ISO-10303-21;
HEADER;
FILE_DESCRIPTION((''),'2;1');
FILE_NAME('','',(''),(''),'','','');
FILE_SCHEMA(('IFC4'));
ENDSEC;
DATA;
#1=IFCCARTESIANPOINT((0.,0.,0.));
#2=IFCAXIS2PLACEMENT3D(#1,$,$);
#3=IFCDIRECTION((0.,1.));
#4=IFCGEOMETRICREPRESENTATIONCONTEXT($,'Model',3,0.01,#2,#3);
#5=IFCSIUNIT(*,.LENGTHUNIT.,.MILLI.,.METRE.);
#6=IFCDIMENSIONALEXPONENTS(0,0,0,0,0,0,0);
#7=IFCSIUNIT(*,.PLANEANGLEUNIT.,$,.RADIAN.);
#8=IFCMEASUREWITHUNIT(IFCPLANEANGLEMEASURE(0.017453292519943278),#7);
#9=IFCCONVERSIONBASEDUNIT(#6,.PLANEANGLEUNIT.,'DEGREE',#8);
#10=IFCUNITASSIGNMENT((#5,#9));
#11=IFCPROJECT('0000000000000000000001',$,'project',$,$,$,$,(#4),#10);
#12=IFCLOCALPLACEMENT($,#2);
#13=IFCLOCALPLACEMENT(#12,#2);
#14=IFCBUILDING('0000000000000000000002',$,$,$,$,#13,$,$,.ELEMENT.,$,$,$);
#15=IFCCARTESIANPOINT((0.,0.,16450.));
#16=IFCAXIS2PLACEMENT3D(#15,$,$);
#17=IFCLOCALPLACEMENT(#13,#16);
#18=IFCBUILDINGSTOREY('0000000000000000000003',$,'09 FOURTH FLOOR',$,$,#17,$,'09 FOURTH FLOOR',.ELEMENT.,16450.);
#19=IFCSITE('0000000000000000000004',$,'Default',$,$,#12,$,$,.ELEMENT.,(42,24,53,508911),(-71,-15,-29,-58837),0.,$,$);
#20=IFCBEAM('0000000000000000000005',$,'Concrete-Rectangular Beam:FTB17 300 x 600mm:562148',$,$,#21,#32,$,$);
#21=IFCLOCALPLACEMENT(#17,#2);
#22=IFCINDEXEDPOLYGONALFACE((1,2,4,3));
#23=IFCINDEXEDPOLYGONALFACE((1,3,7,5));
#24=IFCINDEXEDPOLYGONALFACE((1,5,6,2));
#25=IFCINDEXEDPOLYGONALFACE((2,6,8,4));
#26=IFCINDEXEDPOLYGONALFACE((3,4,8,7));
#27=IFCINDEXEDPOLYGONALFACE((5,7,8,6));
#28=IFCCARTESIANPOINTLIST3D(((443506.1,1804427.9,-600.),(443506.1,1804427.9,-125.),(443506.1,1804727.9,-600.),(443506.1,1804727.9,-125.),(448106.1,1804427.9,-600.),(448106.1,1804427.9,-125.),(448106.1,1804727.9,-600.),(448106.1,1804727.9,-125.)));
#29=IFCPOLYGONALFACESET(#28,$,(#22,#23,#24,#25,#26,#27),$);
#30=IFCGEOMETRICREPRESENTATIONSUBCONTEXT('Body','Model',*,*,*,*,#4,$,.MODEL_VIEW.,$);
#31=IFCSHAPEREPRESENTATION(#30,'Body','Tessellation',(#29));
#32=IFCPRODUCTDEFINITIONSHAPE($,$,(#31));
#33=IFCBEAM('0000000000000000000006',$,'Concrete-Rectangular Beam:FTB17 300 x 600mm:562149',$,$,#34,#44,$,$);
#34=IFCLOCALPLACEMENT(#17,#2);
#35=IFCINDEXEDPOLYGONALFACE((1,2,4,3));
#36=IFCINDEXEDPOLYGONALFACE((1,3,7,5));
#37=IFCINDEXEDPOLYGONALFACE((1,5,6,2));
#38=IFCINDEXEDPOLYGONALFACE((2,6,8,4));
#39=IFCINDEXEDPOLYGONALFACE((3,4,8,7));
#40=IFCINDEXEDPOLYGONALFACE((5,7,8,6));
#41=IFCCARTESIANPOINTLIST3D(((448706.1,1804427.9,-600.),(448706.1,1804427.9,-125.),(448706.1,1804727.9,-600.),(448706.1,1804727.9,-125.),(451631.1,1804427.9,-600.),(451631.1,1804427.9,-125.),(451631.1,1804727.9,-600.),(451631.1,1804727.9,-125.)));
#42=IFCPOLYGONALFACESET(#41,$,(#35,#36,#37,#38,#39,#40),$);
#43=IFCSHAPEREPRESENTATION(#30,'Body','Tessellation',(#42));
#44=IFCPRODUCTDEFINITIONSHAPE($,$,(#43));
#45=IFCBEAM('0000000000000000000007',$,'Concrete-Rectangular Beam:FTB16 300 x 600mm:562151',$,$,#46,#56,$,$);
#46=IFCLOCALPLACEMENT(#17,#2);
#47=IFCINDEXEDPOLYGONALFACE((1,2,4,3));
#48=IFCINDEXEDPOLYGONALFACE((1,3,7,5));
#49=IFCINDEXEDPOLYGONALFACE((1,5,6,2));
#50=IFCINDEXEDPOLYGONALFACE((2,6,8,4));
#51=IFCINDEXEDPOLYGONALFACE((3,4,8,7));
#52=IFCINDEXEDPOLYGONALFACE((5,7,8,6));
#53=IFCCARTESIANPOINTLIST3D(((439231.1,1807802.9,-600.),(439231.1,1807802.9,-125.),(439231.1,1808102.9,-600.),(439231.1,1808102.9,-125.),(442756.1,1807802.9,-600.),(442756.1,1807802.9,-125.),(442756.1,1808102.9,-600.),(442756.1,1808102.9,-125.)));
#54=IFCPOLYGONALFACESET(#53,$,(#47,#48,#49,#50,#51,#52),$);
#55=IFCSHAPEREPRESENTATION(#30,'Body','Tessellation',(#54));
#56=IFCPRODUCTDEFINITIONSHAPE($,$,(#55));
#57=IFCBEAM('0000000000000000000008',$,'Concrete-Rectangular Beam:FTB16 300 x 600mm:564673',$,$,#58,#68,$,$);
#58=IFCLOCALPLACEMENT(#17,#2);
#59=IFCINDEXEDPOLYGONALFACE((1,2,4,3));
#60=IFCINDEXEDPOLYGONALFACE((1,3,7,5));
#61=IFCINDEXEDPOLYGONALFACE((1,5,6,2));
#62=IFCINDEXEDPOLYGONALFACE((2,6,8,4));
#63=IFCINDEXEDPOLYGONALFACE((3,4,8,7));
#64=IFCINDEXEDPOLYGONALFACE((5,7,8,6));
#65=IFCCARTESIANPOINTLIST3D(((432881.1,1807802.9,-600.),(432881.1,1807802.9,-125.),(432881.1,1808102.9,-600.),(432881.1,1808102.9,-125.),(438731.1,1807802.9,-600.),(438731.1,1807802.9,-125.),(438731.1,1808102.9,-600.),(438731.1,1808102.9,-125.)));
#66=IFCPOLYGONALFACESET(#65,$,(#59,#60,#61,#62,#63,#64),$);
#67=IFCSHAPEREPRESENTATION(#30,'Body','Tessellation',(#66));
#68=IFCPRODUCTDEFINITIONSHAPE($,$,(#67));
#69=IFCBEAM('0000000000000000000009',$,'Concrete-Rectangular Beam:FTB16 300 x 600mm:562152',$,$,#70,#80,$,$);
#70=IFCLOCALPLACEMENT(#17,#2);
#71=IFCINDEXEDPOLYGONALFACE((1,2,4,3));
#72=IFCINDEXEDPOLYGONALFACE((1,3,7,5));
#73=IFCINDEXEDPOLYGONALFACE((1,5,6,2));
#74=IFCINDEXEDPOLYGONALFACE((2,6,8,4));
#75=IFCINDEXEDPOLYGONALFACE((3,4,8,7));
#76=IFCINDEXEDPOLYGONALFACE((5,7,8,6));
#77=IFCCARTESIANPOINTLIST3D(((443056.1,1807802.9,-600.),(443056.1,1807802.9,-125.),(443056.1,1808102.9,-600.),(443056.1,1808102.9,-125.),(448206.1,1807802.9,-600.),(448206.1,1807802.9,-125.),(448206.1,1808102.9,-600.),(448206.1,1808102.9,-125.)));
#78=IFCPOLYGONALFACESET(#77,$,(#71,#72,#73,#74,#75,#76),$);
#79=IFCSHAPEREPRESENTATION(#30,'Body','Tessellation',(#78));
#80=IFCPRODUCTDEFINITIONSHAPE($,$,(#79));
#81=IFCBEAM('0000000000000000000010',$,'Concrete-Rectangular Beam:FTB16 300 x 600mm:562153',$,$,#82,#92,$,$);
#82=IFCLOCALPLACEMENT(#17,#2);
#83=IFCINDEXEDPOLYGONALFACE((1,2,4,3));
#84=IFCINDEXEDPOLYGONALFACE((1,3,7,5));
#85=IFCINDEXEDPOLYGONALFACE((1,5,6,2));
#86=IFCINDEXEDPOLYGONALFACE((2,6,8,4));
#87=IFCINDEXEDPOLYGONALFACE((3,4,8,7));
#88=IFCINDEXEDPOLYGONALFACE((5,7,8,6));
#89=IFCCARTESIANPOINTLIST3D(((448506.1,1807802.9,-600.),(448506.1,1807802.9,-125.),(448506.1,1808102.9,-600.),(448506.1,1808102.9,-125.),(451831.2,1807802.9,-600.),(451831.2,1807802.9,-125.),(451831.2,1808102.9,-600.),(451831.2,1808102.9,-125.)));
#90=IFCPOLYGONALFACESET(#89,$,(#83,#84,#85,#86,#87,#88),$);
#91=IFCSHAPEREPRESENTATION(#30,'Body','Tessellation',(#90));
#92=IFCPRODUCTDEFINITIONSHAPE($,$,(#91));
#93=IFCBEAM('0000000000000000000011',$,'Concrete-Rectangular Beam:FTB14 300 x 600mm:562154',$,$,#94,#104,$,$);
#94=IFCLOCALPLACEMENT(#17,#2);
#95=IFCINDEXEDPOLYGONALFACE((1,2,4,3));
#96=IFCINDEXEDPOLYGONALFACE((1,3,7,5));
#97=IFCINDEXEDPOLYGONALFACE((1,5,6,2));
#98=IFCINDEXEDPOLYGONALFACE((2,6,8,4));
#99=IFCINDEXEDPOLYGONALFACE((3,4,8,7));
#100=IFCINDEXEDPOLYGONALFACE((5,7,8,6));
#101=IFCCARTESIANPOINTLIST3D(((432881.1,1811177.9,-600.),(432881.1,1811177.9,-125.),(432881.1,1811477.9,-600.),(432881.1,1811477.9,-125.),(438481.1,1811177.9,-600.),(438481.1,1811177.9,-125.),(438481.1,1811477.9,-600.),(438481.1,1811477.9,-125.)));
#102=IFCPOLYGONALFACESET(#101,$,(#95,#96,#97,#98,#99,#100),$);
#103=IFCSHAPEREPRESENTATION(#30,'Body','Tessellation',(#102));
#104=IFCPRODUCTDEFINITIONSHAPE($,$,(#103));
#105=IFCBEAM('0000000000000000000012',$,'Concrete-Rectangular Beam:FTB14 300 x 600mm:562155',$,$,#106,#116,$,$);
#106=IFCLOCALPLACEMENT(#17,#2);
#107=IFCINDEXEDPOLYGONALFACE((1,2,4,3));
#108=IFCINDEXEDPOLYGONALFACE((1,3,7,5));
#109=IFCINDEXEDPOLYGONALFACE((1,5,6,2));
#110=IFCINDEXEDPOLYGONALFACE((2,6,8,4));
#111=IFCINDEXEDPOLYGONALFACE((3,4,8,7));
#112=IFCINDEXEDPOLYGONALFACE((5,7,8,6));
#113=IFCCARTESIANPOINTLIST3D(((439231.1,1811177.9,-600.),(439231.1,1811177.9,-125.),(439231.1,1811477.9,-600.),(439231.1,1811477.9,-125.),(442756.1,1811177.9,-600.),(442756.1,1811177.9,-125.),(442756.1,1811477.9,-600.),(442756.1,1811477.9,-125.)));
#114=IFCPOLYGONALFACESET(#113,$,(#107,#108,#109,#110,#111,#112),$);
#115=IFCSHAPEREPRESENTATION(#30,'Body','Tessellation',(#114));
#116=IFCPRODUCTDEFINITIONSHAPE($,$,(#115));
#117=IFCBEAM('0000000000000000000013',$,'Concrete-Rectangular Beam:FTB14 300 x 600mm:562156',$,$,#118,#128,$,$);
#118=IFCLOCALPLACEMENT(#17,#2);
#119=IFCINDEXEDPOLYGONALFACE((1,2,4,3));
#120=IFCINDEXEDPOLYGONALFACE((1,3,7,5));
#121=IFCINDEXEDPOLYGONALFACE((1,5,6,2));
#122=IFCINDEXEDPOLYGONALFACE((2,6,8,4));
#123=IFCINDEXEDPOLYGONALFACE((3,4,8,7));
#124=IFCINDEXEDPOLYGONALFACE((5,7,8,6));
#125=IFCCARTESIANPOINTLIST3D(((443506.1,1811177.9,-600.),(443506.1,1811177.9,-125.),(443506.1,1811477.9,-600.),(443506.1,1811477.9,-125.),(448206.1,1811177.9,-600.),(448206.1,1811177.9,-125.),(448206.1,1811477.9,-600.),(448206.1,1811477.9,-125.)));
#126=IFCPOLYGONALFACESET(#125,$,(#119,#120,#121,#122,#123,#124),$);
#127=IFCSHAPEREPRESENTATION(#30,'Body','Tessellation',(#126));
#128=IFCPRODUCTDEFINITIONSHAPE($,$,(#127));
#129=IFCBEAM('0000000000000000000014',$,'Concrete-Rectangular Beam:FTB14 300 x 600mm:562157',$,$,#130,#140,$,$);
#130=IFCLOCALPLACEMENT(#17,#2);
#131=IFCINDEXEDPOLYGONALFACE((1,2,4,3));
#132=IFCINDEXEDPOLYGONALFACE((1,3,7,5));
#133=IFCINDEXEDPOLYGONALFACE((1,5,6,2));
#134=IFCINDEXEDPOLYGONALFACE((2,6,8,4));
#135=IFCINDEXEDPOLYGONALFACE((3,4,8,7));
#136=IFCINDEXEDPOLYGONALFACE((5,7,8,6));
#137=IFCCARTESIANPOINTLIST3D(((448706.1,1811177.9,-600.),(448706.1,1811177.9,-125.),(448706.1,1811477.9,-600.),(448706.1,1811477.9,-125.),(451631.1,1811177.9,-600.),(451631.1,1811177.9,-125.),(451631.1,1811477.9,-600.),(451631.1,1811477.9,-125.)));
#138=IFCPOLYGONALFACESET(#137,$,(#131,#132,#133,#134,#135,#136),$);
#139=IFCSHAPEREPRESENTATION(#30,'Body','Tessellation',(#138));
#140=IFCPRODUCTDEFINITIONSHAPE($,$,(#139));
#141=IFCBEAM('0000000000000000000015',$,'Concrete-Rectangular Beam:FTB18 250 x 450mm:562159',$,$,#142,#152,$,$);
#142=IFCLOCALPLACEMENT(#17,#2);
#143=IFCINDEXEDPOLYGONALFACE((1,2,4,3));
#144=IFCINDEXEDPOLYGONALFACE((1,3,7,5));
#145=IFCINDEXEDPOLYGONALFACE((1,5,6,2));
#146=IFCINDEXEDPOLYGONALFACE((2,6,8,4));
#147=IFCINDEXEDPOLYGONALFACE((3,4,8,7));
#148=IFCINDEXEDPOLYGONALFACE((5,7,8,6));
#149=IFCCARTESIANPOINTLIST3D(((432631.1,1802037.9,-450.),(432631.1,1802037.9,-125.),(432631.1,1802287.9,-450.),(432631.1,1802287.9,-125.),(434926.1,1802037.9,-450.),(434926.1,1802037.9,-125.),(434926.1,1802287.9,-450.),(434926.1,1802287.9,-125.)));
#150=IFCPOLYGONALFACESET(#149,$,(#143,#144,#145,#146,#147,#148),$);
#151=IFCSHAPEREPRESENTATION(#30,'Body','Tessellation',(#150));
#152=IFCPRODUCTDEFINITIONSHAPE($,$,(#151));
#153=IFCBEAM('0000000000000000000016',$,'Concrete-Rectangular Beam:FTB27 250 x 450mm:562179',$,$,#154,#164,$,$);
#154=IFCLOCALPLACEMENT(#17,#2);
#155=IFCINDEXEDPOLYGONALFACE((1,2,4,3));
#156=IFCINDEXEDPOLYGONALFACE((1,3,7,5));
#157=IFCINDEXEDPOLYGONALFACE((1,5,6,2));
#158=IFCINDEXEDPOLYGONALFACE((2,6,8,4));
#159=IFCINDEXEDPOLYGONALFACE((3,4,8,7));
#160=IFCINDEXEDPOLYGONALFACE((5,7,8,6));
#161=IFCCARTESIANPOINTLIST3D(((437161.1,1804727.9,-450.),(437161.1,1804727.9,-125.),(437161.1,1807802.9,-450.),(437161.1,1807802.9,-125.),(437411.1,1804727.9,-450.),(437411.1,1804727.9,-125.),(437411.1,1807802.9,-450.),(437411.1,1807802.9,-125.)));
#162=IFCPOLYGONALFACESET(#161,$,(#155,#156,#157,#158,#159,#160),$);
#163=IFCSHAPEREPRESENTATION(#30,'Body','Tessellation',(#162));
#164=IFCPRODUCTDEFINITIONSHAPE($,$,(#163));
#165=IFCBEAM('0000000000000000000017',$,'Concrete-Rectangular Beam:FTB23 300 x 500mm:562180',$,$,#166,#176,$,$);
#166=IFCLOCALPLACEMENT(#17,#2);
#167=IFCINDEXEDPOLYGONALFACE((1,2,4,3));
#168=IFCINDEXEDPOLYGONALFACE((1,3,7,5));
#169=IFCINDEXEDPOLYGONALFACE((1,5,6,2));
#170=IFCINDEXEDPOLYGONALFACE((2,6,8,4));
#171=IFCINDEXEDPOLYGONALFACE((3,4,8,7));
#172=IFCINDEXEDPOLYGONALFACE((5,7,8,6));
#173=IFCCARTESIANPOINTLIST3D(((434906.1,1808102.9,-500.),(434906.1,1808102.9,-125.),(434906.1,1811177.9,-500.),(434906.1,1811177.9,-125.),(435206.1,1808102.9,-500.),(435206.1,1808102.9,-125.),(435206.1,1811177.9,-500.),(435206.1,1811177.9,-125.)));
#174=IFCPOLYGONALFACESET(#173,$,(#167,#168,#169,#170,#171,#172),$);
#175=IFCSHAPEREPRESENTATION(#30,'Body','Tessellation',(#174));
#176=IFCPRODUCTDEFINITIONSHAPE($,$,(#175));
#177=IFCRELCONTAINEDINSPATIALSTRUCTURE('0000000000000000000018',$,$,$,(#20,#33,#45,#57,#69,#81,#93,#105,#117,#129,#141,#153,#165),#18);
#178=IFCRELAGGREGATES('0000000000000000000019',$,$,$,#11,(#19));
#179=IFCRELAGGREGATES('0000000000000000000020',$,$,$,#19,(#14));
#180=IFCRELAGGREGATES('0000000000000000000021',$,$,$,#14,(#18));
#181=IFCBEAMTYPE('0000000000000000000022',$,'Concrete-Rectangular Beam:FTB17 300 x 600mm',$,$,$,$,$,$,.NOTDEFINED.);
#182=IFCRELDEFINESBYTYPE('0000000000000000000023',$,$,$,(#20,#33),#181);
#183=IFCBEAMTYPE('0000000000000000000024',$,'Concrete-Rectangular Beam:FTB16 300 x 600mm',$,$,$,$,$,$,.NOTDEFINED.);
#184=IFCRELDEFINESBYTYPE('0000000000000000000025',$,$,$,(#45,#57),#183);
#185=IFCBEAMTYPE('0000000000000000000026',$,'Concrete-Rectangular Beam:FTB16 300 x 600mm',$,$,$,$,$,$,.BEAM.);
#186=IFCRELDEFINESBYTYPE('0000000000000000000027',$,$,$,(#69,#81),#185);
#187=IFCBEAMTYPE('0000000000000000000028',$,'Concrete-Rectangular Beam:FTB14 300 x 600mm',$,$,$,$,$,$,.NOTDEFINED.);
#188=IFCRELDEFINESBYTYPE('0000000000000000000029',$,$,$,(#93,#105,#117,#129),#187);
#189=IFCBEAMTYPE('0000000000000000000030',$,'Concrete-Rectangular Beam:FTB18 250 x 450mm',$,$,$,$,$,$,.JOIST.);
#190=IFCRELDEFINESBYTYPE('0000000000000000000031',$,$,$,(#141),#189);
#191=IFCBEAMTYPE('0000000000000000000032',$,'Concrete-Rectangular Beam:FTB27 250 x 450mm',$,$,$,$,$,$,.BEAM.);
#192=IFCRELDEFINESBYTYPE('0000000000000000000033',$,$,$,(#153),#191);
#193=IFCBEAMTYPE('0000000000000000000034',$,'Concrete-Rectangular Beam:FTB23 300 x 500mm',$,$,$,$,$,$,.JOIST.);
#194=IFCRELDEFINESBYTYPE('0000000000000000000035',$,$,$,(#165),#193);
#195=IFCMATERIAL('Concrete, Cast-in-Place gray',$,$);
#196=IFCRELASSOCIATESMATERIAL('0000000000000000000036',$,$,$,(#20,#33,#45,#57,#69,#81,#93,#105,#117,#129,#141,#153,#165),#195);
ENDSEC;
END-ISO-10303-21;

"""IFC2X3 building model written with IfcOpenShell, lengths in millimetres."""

from ifc_helpers import new_model, entity, si_unit, converted_unit, direction, frame, frame_2d, origin, origin_2d_with_axis, place, context, subcontext, project, spatial, rectangle, extrude, material, type_object, element, save


model = new_model("IFC2X3")

# Units and contexts
model_context = context("Model", 3, precision=0.01, world=origin(), true_north=direction((0.0, 1.0)))
body_context = subcontext(model_context, "Body", "Model", "MODEL_VIEW")
ifc_project = project(units=[si_unit("LENGTHUNIT", "METRE", prefix="MILLI"), converted_unit("PLANEANGLEUNIT", "DEGREE", entity("IfcPlaneAngleMeasure", 0.017453292519943278), si_unit("PLANEANGLEUNIT", "RADIAN"), dimensions=[0, 0, 0, 0, 0, 0, 0])], contexts=[model_context])

# Site, building, storey
site_placement = place(None, origin())
site = spatial("IfcSite", under=ifc_project, at=site_placement, Name="Default", CompositionType="ELEMENT", RefLatitude=(42, 24, 53, 508911), RefLongitude=(-71, -15, -29, -58837), RefElevation=0.0)
building_placement = place(site_placement, origin())
building = spatial("IfcBuilding", under=site, at=building_placement, CompositionType="ELEMENT")
storey_placement = place(building_placement, frame((0.0, 0.0, 16450.0)))
storey = spatial("IfcBuildingStorey", under=building, at=storey_placement, Name="09 FOURTH FLOOR", LongName="09 FOURTH FLOOR", CompositionType="ELEMENT", Elevation=16450.0)

# Beams
ifc_material = material(Name="Concrete, Cast-in-Place gray")
beam_type_1 = type_object("IfcBeamType", Name="Concrete-Rectangular Beam:FTB17 300 x 600mm", PredefinedType="NOTDEFINED")
beam_1_placement = place(storey_placement, frame((443506.1, 1804727.9, 0.0)))
element("IfcBeam", 1, at=beam_1_placement, inside=storey, type_object=beam_type_1, material=ifc_material, Name="Concrete-Rectangular Beam:FTB17 300 x 600mm:562148", context=body_context, shape_type="SweptSolid", body=[
    extrude(rectangle(XDim=475.0, YDim=300.0, at=frame_2d((0.0, 0.0), x_axis=(1.0, 0.0))), frame((0.0, -150.0, -362.5), z_axis=(1.0, 0.0, 0.0), x_axis=(0.0, 0.0, -1.0)), (0.0, 0.0, 1.0), 4600.0),
])
beam_2_placement = place(storey_placement, frame((448706.1, 1804727.9, 0.0)))
element("IfcBeam", 2, at=beam_2_placement, inside=storey, type_object=beam_type_1, material=ifc_material, Name="Concrete-Rectangular Beam:FTB17 300 x 600mm:562149", context=body_context, shape_type="SweptSolid", body=[
    extrude(rectangle(XDim=475.0, YDim=300.0, at=frame_2d((0.0, 0.0), x_axis=(1.0, 0.0))), frame((0.0, -150.0, -362.5), z_axis=(1.0, 0.0, 0.0), x_axis=(0.0, 0.0, -1.0)), (0.0, 0.0, 1.0), 2925.0),
])
beam_type_2 = type_object("IfcBeamType", Name="Concrete-Rectangular Beam:FTB16 300 x 600mm", PredefinedType="NOTDEFINED")
beam_3_placement = place(storey_placement, frame((439231.1, 1808102.9, 0.0)))
element("IfcBeam", 3, at=beam_3_placement, inside=storey, type_object=beam_type_2, material=ifc_material, Name="Concrete-Rectangular Beam:FTB16 300 x 600mm:562151", context=body_context, shape_type="SweptSolid", body=[
    extrude(rectangle(XDim=475.0, YDim=300.0, at=frame_2d((0.0, 0.0), x_axis=(1.0, 0.0))), frame((0.0, -150.0, -362.5), z_axis=(1.0, 0.0, 0.0), x_axis=(0.0, 0.0, -1.0)), (0.0, 0.0, 1.0), 3525.0),
])
beam_4_placement = place(storey_placement, frame((432881.1, 1808102.9, 0.0)))
element("IfcBeam", 4, at=beam_4_placement, inside=storey, type_object=beam_type_2, material=ifc_material, Name="Concrete-Rectangular Beam:FTB16 300 x 600mm:564673", context=body_context, shape_type="SweptSolid", body=[
    extrude(rectangle(XDim=475.0, YDim=300.0, at=frame_2d((0.0, 0.0), x_axis=(1.0, 0.0))), frame((0.0, -150.0, -362.5), z_axis=(1.0, 0.0, 0.0), x_axis=(0.0, 0.0, -1.0)), (0.0, 0.0, 1.0), 5850.0),
])
beam_type_3 = type_object("IfcBeamType", Name="Concrete-Rectangular Beam:FTB16 300 x 600mm", PredefinedType="BEAM")
beam_5_placement = place(storey_placement, frame((443056.1, 1808102.9, 0.0)))
element("IfcBeam", 5, at=beam_5_placement, inside=storey, type_object=beam_type_3, material=ifc_material, Name="Concrete-Rectangular Beam:FTB16 300 x 600mm:562152", context=body_context, shape_type="SweptSolid", body=[
    extrude(rectangle(XDim=475.0, YDim=300.0, at=frame_2d((0.0, 0.0), x_axis=(1.0, 0.0))), frame((0.0, -150.0, -362.5), z_axis=(1.0, 0.0, 0.0), x_axis=(0.0, 0.0, -1.0)), (0.0, 0.0, 1.0), 5150.0),
])
beam_6_placement = place(storey_placement, frame((448506.1, 1808102.9, 0.0)))
element("IfcBeam", 6, at=beam_6_placement, inside=storey, type_object=beam_type_3, material=ifc_material, Name="Concrete-Rectangular Beam:FTB16 300 x 600mm:562153", context=body_context, shape_type="SweptSolid", body=[
    extrude(rectangle(XDim=475.0, YDim=300.0, at=frame_2d((0.0, 0.0), x_axis=(1.0, 0.0))), frame((0.0, -150.0, -362.5), z_axis=(1.0, 0.0, 0.0), x_axis=(0.0, 0.0, -1.0)), (0.0, 0.0, 1.0), 3325.1),
])
beam_type_4 = type_object("IfcBeamType", Name="Concrete-Rectangular Beam:FTB14 300 x 600mm", PredefinedType="NOTDEFINED")
beam_7_placement = place(storey_placement, frame((432881.1, 1811177.9, 0.0)))
element("IfcBeam", 7, at=beam_7_placement, inside=storey, type_object=beam_type_4, material=ifc_material, Name="Concrete-Rectangular Beam:FTB14 300 x 600mm:562154", context=body_context, shape_type="SweptSolid", body=[
    extrude(rectangle(XDim=475.0, YDim=300.0, at=frame_2d((0.0, 0.0), x_axis=(1.0, 0.0))), frame((0.0, 150.0, -362.5), z_axis=(1.0, 0.0, 0.0), x_axis=(0.0, 0.0, -1.0)), (0.0, 0.0, 1.0), 5600.0),
])
beam_8_placement = place(storey_placement, frame((439231.1, 1811177.9, 0.0)))
element("IfcBeam", 8, at=beam_8_placement, inside=storey, type_object=beam_type_4, material=ifc_material, Name="Concrete-Rectangular Beam:FTB14 300 x 600mm:562155", context=body_context, shape_type="SweptSolid", body=[
    extrude(rectangle(XDim=475.0, YDim=300.0, at=frame_2d((0.0, 0.0), x_axis=(1.0, 0.0))), frame((0.0, 150.0, -362.5), z_axis=(1.0, 0.0, 0.0), x_axis=(0.0, 0.0, -1.0)), (0.0, 0.0, 1.0), 3525.0),
])
beam_9_placement = place(storey_placement, frame((443506.1, 1811177.9, 0.0)))
element("IfcBeam", 9, at=beam_9_placement, inside=storey, type_object=beam_type_4, material=ifc_material, Name="Concrete-Rectangular Beam:FTB14 300 x 600mm:562156", context=body_context, shape_type="SweptSolid", body=[
    extrude(rectangle(XDim=475.0, YDim=300.0, at=frame_2d((0.0, 0.0), x_axis=(1.0, 0.0))), frame((0.0, 150.0, -362.5), z_axis=(1.0, 0.0, 0.0), x_axis=(0.0, 0.0, -1.0)), (0.0, 0.0, 1.0), 4700.0),
])
beam_10_placement = place(storey_placement, frame((448706.1, 1811177.9, 0.0)))
element("IfcBeam", 10, at=beam_10_placement, inside=storey, type_object=beam_type_4, material=ifc_material, Name="Concrete-Rectangular Beam:FTB14 300 x 600mm:562157", context=body_context, shape_type="SweptSolid", body=[
    extrude(rectangle(XDim=475.0, YDim=300.0, at=frame_2d((0.0, 0.0), x_axis=(1.0, 0.0))), frame((0.0, 150.0, -362.5), z_axis=(1.0, 0.0, 0.0), x_axis=(0.0, 0.0, -1.0)), (0.0, 0.0, 1.0), 2925.0),
])
beam_type_5 = type_object("IfcBeamType", Name="Concrete-Rectangular Beam:FTB18 250 x 450mm", PredefinedType="JOIST")
beam_11_placement = place(storey_placement, frame((432631.1, 1802287.9, 0.0)))
element("IfcBeam", 11, at=beam_11_placement, inside=storey, type_object=beam_type_5, material=ifc_material, Name="Concrete-Rectangular Beam:FTB18 250 x 450mm:562159", context=body_context, shape_type="SweptSolid", body=[
    extrude(rectangle(XDim=325.0, YDim=250.0, at=frame_2d((0.0, 0.0), x_axis=(1.0, 0.0))), frame((0.0, -125.0, -287.5), z_axis=(1.0, 0.0, 0.0), x_axis=(0.0, 0.0, -1.0)), (0.0, 0.0, 1.0), 2295.0),
])
beam_type_6 = type_object("IfcBeamType", Name="Concrete-Rectangular Beam:FTB27 250 x 450mm", PredefinedType="BEAM")
beam_12_placement = place(storey_placement, frame((437161.1, 1807802.9, 0.0), z_axis=(0.0, 0.0, 1.0), x_axis=(0.0, -1.0, 0.0)))
element("IfcBeam", 12, at=beam_12_placement, inside=storey, type_object=beam_type_6, material=ifc_material, Name="Concrete-Rectangular Beam:FTB27 250 x 450mm:562179", context=body_context, shape_type="SweptSolid", body=[
    extrude(rectangle(XDim=325.0, YDim=250.0, at=frame_2d((0.0, 0.0), x_axis=(1.0, 0.0))), frame((0.0, 125.0, -287.5), z_axis=(1.0, 0.0, 0.0), x_axis=(0.0, 0.0, -1.0)), (0.0, 0.0, 1.0), 3075.0),
])
beam_type_7 = type_object("IfcBeamType", Name="Concrete-Rectangular Beam:FTB23 300 x 500mm", PredefinedType="JOIST")
beam_13_placement = place(storey_placement, frame((434906.1, 1811177.9, 0.0), z_axis=(0.0, 0.0, 1.0), x_axis=(0.0, -1.0, 0.0)))
element("IfcBeam", 13, at=beam_13_placement, inside=storey, type_object=beam_type_7, material=ifc_material, Name="Concrete-Rectangular Beam:FTB23 300 x 500mm:562180", context=body_context, shape_type="SweptSolid", body=[
    extrude(rectangle(XDim=375.0, YDim=300.0, at=origin_2d_with_axis()), frame((0.0, 150.0, -312.5), z_axis=(1.0, 0.0, 0.0), x_axis=(0.0, 0.0, -1.0)), (0.0, 0.0, 1.0), 3075.0),
])

save(model, "model.ifc")
